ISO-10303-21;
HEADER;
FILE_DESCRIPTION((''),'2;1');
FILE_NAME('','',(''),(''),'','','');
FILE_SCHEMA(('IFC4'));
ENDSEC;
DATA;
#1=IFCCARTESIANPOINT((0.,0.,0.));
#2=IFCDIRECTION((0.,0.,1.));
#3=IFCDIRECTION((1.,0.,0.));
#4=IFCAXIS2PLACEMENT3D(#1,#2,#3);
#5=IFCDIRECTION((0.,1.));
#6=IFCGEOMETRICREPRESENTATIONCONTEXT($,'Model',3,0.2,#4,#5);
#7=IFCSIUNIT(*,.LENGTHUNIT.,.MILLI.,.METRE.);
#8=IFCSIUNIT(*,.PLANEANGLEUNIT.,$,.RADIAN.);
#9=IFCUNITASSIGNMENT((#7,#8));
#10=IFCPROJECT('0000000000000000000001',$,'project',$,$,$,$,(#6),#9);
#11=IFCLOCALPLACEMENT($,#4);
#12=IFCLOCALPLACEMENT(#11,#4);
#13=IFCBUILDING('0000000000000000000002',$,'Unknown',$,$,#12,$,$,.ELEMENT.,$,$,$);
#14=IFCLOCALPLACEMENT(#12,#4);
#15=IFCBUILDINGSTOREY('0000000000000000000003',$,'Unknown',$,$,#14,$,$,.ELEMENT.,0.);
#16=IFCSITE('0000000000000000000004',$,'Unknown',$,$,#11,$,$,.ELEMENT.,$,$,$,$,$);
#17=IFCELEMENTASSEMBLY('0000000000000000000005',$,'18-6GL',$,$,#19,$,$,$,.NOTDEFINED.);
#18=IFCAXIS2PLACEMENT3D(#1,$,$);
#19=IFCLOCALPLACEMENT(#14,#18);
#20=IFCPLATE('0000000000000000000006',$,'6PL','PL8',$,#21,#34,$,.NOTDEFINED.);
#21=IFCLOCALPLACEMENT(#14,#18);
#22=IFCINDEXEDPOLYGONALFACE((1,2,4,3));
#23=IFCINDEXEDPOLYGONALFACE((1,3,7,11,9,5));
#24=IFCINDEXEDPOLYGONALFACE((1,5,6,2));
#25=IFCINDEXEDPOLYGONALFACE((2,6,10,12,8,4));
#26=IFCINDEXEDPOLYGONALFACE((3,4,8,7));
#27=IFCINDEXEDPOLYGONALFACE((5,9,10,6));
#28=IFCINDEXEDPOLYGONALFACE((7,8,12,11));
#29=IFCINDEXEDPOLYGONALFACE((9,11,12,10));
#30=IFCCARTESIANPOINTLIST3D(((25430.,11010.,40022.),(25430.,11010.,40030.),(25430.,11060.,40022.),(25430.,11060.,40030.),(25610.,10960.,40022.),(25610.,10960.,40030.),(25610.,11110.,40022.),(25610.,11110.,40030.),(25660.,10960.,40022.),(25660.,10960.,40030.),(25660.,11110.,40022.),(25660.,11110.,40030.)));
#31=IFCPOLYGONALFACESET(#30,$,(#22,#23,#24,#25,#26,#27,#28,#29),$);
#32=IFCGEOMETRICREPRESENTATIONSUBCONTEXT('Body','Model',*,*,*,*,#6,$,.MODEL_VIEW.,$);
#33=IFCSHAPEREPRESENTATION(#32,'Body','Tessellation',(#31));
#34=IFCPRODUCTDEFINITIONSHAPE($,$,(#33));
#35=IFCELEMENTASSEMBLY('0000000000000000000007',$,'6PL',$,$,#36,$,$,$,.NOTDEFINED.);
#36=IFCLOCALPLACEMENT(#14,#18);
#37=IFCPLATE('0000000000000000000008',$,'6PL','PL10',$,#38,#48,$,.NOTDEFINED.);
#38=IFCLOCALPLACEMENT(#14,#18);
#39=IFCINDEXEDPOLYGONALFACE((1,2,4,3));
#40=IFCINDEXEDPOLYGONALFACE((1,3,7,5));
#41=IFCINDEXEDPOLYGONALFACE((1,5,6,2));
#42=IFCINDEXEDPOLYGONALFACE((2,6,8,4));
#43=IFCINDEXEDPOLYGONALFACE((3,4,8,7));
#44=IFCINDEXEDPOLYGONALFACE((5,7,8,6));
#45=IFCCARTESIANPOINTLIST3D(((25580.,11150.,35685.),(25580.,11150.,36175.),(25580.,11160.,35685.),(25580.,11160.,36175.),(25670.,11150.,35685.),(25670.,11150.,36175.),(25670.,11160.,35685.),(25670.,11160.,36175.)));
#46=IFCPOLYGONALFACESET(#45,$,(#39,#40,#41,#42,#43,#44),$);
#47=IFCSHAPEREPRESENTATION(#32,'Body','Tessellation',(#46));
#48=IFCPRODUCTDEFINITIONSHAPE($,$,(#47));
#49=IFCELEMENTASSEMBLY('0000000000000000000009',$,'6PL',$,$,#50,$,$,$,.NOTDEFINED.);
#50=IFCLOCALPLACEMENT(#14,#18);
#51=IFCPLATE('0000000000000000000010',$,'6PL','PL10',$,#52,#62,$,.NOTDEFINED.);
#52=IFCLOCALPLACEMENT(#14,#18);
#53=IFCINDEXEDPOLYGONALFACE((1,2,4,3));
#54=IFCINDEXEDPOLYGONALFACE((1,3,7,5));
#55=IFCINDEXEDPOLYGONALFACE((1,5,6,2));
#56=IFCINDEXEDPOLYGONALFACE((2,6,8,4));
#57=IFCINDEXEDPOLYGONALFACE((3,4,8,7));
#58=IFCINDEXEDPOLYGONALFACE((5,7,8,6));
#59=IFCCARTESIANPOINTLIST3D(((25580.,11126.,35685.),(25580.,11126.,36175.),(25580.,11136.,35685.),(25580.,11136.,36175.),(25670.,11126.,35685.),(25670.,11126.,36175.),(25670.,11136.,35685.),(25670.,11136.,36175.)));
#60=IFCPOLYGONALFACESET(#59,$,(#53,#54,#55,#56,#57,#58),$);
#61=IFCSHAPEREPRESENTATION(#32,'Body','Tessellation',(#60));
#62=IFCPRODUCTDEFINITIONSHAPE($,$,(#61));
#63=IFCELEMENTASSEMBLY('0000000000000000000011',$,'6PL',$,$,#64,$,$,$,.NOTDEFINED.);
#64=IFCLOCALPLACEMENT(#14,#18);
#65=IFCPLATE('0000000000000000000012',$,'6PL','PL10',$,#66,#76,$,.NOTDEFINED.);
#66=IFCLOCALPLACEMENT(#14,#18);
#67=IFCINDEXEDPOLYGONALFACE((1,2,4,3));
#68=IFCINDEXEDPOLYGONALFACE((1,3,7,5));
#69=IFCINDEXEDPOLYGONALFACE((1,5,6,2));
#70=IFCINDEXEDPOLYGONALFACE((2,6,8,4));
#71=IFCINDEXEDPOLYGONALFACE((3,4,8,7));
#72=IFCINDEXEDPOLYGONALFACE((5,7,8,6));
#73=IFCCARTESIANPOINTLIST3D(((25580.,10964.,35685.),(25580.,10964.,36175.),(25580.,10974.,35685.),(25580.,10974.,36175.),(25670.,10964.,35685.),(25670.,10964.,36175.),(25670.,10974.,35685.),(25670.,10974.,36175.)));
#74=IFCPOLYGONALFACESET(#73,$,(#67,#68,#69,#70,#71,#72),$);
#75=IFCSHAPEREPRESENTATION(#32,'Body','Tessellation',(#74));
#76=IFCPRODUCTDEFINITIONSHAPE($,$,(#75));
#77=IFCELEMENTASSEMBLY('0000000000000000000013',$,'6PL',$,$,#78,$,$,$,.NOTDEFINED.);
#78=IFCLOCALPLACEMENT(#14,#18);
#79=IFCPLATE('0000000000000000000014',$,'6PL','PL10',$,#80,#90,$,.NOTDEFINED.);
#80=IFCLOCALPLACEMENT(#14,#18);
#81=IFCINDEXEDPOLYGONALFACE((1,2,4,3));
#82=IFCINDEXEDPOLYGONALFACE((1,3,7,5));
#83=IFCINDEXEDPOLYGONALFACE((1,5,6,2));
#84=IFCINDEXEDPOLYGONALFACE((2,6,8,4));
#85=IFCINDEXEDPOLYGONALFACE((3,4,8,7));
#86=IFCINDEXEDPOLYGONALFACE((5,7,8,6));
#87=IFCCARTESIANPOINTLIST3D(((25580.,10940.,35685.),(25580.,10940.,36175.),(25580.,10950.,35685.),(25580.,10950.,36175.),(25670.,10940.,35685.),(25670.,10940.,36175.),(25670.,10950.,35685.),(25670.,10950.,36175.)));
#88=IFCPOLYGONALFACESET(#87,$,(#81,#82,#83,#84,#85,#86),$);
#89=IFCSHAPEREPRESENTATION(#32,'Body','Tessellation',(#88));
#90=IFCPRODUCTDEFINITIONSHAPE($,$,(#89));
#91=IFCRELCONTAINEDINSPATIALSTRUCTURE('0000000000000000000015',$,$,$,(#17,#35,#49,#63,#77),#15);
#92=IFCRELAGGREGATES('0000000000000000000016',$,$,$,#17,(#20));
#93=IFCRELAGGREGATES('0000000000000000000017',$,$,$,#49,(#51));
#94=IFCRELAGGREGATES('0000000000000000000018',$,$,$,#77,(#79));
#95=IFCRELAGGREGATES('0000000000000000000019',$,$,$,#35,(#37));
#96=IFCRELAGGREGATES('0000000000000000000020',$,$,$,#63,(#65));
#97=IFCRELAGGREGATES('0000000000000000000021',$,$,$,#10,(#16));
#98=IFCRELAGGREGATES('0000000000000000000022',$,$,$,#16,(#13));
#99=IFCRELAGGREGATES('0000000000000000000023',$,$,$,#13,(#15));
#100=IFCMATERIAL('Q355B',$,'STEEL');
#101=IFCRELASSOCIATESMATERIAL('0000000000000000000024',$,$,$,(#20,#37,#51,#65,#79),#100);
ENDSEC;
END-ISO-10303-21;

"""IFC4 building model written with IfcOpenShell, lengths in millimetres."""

from ifc_helpers import new_model, si_unit, direction, frame, origin_with_axes, place, context, subcontext, project, spatial, line, indexed_curve, outline, extrude, material, element, aggregate, save


model = new_model("IFC4")

# Units and contexts
model_context = context("Model", 3, precision=0.2, world=origin_with_axes(), true_north=direction((0.0, 1.0)))
body_context = subcontext(model_context, "Body", "Model", "MODEL_VIEW")
ifc_project = project(units=[si_unit("LENGTHUNIT", "METRE", prefix="MILLI"), si_unit("PLANEANGLEUNIT", "RADIAN")], contexts=[model_context])

# Site, building, storey
site_placement = place(None, origin_with_axes())
site = spatial("IfcSite", under=ifc_project, at=site_placement, Name="Unknown", CompositionType="ELEMENT")
building_placement = place(site_placement, origin_with_axes())
building = spatial("IfcBuilding", under=site, at=building_placement, Name="Unknown", CompositionType="ELEMENT")
storey_placement = place(building_placement, origin_with_axes())
storey = spatial("IfcBuildingStorey", under=building, at=storey_placement, Name="Unknown", CompositionType="ELEMENT", Elevation=0.0)

# Shared definitions
ifc_material_1 = material(Name="Q355B", Category="STEEL")

# Element assembly, plate
assembly_1_placement = place(storey_placement, frame((21150.0, 11035.0, 40240.0), z_axis=(0.0, -1.0, 0.0), x_axis=(1.0, 0.0, 0.0)))
assembly_1 = element("IfcElementAssembly", 1, at=assembly_1_placement, inside=storey, Name="18-6GL", PredefinedType="NOTDEFINED")
plate_1_placement = place(assembly_1_placement, frame((4460.0, -214.0, 75.0), z_axis=(0.0, 1.0, 0.0), x_axis=(1.0, 0.0, 0.0)))
plate_1 = element("IfcPlate", 2, at=plate_1_placement, material=ifc_material_1, Name="6PL", Description="PL8", PredefinedType="NOTDEFINED", context=body_context, shape_type="SolidModel", body=[
    extrude(outline(indexed_curve([(0.0, 0.0), (50.0, 0.0), (50.0, 150.0), (0.0, 150.0), (-180.0, 100.0), (-180.0, 50.0)], segments=[line(1, 2, 3, 4, 5, 6, 1)])), frame((0.0, 0.0, 4.0), z_axis=(0.0, 0.0, 1.0), x_axis=(1.0, 0.0, 0.0)), (0.0, 0.0, -1.0), 8.0),
])
aggregate(assembly_1, [plate_1])

# Element assemblies, plates
assembly_2_placement = place(storey_placement, frame((25580.0, 11155.0, 36175.0), z_axis=(0.0, 1.0, 0.0), x_axis=(1.0, 0.0, 0.0)))
assembly_2 = element("IfcElementAssembly", 3, at=assembly_2_placement, inside=storey, Name="6PL", PredefinedType="NOTDEFINED")
plate_2_placement = place(assembly_2_placement, origin_with_axes())
plate_2 = element("IfcPlate", 4, at=plate_2_placement, material=ifc_material_1, Name="6PL", Description="PL10", PredefinedType="NOTDEFINED", context=body_context, shape_type="SolidModel", body=[
    extrude(outline(indexed_curve([(0.0, 0.0), (90.0, 0.0), (90.0, 490.0), (0.0, 490.0)], segments=[line(1, 2, 3, 4, 1)])), frame((0.0, 0.0, 5.0), z_axis=(0.0, 0.0, 1.0), x_axis=(1.0, 0.0, 0.0)), (0.0, 0.0, -1.0), 10.0),
])
assembly_3_placement = place(storey_placement, frame((25580.0, 11131.0, 36175.0), z_axis=(0.0, 1.0, 0.0), x_axis=(1.0, 0.0, 0.0)))
assembly_3 = element("IfcElementAssembly", 5, at=assembly_3_placement, inside=storey, Name="6PL", PredefinedType="NOTDEFINED")
plate_3_placement = place(assembly_3_placement, origin_with_axes())
plate_3 = element("IfcPlate", 6, at=plate_3_placement, material=ifc_material_1, Name="6PL", Description="PL10", PredefinedType="NOTDEFINED", context=body_context, shape_type="SolidModel", body=[
    extrude(outline(indexed_curve([(0.0, 0.0), (90.0, 0.0), (90.0, 490.0), (0.0, 490.0)], segments=[line(1, 2, 3, 4, 1)])), frame((0.0, 0.0, 5.0), z_axis=(0.0, 0.0, 1.0), x_axis=(1.0, 0.0, 0.0)), (0.0, 0.0, -1.0), 10.0),
])
aggregate(assembly_3, [plate_3])
assembly_4_placement = place(storey_placement, frame((25580.0, 10969.0, 36175.0), z_axis=(0.0, 1.0, 0.0), x_axis=(1.0, 0.0, 0.0)))
assembly_4 = element("IfcElementAssembly", 7, at=assembly_4_placement, inside=storey, Name="6PL", PredefinedType="NOTDEFINED")
plate_4_placement = place(assembly_4_placement, origin_with_axes())
plate_4 = element("IfcPlate", 8, at=plate_4_placement, material=ifc_material_1, Name="6PL", Description="PL10", PredefinedType="NOTDEFINED", context=body_context, shape_type="SolidModel", body=[
    extrude(outline(indexed_curve([(0.0, 0.0), (90.0, 0.0), (90.0, 490.0), (0.0, 490.0)], segments=[line(1, 2, 3, 4, 1)])), frame((0.0, 0.0, 5.0), z_axis=(0.0, 0.0, 1.0), x_axis=(1.0, 0.0, 0.0)), (0.0, 0.0, -1.0), 10.0),
])
assembly_5_placement = place(storey_placement, frame((25580.0, 10945.0, 36175.0), z_axis=(0.0, 1.0, 0.0), x_axis=(1.0, 0.0, 0.0)))
assembly_5 = element("IfcElementAssembly", 9, at=assembly_5_placement, inside=storey, Name="6PL", PredefinedType="NOTDEFINED")
plate_5_placement = place(assembly_5_placement, origin_with_axes())
plate_5 = element("IfcPlate", 10, at=plate_5_placement, material=ifc_material_1, Name="6PL", Description="PL10", PredefinedType="NOTDEFINED", context=body_context, shape_type="SolidModel", body=[
    extrude(outline(indexed_curve([(0.0, 0.0), (90.0, 0.0), (90.0, 490.0), (0.0, 490.0)], segments=[line(1, 2, 3, 4, 1)])), frame((0.0, 0.0, 5.0), z_axis=(0.0, 0.0, 1.0), x_axis=(1.0, 0.0, 0.0)), (0.0, 0.0, -1.0), 10.0),
])
aggregate(assembly_5, [plate_5])

aggregate(assembly_2, [plate_2])
aggregate(assembly_4, [plate_4])

save(model, "model.ifc")
